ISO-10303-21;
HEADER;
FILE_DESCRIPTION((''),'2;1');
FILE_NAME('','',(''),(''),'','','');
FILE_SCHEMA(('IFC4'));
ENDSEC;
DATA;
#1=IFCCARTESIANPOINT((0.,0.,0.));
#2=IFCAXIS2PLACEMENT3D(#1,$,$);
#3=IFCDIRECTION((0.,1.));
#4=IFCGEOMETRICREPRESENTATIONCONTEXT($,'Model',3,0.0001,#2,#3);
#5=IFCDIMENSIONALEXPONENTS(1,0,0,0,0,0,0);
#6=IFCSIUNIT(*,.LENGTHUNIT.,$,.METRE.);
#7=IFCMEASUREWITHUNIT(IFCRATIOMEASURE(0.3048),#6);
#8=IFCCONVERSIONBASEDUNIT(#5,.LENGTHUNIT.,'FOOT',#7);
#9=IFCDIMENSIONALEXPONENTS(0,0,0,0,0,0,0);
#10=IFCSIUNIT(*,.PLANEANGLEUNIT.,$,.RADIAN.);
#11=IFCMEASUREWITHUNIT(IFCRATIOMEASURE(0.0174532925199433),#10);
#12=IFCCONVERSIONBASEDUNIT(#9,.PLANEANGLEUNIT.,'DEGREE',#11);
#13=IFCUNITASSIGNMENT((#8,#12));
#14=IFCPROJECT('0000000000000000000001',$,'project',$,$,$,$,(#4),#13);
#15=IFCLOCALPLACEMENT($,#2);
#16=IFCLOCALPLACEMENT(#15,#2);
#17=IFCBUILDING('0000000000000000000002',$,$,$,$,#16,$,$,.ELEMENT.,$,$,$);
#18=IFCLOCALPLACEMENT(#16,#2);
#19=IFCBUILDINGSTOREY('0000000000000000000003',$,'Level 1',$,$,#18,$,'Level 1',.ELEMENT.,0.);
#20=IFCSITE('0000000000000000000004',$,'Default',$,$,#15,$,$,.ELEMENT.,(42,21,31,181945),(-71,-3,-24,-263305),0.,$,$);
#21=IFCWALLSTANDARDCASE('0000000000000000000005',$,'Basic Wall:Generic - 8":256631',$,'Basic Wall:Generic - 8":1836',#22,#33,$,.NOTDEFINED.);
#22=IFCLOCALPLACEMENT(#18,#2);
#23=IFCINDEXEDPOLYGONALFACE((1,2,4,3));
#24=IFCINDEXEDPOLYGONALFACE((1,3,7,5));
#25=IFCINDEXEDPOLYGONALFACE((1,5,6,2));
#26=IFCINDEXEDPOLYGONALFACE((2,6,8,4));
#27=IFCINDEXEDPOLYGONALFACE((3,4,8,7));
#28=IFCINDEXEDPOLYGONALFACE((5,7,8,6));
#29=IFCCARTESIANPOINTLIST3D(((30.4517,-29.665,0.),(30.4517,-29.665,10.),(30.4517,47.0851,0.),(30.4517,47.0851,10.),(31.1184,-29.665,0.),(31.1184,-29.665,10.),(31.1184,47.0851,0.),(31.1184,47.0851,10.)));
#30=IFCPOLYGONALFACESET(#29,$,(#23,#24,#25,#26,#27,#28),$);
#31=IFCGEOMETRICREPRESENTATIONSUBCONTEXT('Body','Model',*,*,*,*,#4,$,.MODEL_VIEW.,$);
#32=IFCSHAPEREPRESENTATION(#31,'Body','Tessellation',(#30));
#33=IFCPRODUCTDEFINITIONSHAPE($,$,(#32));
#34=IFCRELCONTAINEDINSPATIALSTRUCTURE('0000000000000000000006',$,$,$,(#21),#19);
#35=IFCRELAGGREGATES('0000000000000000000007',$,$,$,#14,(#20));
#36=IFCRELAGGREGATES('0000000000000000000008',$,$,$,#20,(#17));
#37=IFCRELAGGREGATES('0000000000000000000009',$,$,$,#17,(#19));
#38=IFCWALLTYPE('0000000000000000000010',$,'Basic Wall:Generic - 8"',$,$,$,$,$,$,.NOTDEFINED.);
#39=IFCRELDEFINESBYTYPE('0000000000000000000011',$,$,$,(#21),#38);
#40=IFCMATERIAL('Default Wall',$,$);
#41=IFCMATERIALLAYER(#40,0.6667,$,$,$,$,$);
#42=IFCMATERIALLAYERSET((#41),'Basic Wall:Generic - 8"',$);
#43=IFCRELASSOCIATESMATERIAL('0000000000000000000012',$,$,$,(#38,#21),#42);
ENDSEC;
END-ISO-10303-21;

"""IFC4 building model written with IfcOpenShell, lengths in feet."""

from ifc_helpers import new_model, entity, si_unit, converted_unit, direction, frame, frame_2d, origin, place, context, subcontext, project, spatial, rectangle, extrude, material, layer, layer_set, layer_usage, type_object, element, save


model = new_model("IFC4")

# Units and contexts
model_context = context("Model", 3, precision=0.0001, world=origin(), true_north=direction((0.0, 1.0)))
body_context = subcontext(model_context, "Body", "Model", "MODEL_VIEW")
ifc_project = project(units=[converted_unit("LENGTHUNIT", "FOOT", entity("IfcRatioMeasure", 0.3048), si_unit("LENGTHUNIT", "METRE"), dimensions=[1, 0, 0, 0, 0, 0, 0]), converted_unit("PLANEANGLEUNIT", "DEGREE", entity("IfcRatioMeasure", 0.0174532925199433), si_unit("PLANEANGLEUNIT", "RADIAN"), dimensions=[0, 0, 0, 0, 0, 0, 0])], contexts=[model_context])

# Site, building, storey
site_placement = place(None, origin())
site = spatial("IfcSite", under=ifc_project, at=site_placement, Name="Default", CompositionType="ELEMENT", RefLatitude=(42, 21, 31, 181945), RefLongitude=(-71, -3, -24, -263305), RefElevation=0.0)
building_placement = place(site_placement, origin())
building = spatial("IfcBuilding", under=site, at=building_placement, CompositionType="ELEMENT")
storey_placement = place(building_placement, origin())
storey = spatial("IfcBuildingStorey", under=building, at=storey_placement, Name="Level 1", LongName="Level 1", CompositionType="ELEMENT", Elevation=0.0)

# Wall
ifc_material_1 = material(Name="Default Wall")
ifc_layer = layer(ifc_material_1, 0.6667)
ifc_layer_set = layer_set([ifc_layer], Name="Basic Wall:Generic - 8\"")
ifc_layer_usage = layer_usage(ifc_layer_set, "AXIS2", "NEGATIVE", 0.3333)
wall_type = type_object("IfcWallType", Name="Basic Wall:Generic - 8\"", PredefinedType="NOTDEFINED", material=ifc_layer_set)
wall_placement = place(storey_placement, frame((30.785, 47.0851, 0.0), z_axis=(0.0, 0.0, 1.0), x_axis=(0.0, -1.0, 0.0)))
element("IfcWallStandardCase", 1, at=wall_placement, inside=storey, type_object=wall_type, material=ifc_layer_usage, Name="Basic Wall:Generic - 8\":256631", ObjectType="Basic Wall:Generic - 8\":1836", PredefinedType="NOTDEFINED", context=body_context, shape_type="SweptSolid", body=[
    extrude(rectangle(XDim=76.7501, YDim=0.6667, at=frame_2d((38.375, 0.0), x_axis=(-1.0, 0.0))), origin(), (0.0, 0.0, 1.0), 10.0),
])

save(model, "model.ifc")
